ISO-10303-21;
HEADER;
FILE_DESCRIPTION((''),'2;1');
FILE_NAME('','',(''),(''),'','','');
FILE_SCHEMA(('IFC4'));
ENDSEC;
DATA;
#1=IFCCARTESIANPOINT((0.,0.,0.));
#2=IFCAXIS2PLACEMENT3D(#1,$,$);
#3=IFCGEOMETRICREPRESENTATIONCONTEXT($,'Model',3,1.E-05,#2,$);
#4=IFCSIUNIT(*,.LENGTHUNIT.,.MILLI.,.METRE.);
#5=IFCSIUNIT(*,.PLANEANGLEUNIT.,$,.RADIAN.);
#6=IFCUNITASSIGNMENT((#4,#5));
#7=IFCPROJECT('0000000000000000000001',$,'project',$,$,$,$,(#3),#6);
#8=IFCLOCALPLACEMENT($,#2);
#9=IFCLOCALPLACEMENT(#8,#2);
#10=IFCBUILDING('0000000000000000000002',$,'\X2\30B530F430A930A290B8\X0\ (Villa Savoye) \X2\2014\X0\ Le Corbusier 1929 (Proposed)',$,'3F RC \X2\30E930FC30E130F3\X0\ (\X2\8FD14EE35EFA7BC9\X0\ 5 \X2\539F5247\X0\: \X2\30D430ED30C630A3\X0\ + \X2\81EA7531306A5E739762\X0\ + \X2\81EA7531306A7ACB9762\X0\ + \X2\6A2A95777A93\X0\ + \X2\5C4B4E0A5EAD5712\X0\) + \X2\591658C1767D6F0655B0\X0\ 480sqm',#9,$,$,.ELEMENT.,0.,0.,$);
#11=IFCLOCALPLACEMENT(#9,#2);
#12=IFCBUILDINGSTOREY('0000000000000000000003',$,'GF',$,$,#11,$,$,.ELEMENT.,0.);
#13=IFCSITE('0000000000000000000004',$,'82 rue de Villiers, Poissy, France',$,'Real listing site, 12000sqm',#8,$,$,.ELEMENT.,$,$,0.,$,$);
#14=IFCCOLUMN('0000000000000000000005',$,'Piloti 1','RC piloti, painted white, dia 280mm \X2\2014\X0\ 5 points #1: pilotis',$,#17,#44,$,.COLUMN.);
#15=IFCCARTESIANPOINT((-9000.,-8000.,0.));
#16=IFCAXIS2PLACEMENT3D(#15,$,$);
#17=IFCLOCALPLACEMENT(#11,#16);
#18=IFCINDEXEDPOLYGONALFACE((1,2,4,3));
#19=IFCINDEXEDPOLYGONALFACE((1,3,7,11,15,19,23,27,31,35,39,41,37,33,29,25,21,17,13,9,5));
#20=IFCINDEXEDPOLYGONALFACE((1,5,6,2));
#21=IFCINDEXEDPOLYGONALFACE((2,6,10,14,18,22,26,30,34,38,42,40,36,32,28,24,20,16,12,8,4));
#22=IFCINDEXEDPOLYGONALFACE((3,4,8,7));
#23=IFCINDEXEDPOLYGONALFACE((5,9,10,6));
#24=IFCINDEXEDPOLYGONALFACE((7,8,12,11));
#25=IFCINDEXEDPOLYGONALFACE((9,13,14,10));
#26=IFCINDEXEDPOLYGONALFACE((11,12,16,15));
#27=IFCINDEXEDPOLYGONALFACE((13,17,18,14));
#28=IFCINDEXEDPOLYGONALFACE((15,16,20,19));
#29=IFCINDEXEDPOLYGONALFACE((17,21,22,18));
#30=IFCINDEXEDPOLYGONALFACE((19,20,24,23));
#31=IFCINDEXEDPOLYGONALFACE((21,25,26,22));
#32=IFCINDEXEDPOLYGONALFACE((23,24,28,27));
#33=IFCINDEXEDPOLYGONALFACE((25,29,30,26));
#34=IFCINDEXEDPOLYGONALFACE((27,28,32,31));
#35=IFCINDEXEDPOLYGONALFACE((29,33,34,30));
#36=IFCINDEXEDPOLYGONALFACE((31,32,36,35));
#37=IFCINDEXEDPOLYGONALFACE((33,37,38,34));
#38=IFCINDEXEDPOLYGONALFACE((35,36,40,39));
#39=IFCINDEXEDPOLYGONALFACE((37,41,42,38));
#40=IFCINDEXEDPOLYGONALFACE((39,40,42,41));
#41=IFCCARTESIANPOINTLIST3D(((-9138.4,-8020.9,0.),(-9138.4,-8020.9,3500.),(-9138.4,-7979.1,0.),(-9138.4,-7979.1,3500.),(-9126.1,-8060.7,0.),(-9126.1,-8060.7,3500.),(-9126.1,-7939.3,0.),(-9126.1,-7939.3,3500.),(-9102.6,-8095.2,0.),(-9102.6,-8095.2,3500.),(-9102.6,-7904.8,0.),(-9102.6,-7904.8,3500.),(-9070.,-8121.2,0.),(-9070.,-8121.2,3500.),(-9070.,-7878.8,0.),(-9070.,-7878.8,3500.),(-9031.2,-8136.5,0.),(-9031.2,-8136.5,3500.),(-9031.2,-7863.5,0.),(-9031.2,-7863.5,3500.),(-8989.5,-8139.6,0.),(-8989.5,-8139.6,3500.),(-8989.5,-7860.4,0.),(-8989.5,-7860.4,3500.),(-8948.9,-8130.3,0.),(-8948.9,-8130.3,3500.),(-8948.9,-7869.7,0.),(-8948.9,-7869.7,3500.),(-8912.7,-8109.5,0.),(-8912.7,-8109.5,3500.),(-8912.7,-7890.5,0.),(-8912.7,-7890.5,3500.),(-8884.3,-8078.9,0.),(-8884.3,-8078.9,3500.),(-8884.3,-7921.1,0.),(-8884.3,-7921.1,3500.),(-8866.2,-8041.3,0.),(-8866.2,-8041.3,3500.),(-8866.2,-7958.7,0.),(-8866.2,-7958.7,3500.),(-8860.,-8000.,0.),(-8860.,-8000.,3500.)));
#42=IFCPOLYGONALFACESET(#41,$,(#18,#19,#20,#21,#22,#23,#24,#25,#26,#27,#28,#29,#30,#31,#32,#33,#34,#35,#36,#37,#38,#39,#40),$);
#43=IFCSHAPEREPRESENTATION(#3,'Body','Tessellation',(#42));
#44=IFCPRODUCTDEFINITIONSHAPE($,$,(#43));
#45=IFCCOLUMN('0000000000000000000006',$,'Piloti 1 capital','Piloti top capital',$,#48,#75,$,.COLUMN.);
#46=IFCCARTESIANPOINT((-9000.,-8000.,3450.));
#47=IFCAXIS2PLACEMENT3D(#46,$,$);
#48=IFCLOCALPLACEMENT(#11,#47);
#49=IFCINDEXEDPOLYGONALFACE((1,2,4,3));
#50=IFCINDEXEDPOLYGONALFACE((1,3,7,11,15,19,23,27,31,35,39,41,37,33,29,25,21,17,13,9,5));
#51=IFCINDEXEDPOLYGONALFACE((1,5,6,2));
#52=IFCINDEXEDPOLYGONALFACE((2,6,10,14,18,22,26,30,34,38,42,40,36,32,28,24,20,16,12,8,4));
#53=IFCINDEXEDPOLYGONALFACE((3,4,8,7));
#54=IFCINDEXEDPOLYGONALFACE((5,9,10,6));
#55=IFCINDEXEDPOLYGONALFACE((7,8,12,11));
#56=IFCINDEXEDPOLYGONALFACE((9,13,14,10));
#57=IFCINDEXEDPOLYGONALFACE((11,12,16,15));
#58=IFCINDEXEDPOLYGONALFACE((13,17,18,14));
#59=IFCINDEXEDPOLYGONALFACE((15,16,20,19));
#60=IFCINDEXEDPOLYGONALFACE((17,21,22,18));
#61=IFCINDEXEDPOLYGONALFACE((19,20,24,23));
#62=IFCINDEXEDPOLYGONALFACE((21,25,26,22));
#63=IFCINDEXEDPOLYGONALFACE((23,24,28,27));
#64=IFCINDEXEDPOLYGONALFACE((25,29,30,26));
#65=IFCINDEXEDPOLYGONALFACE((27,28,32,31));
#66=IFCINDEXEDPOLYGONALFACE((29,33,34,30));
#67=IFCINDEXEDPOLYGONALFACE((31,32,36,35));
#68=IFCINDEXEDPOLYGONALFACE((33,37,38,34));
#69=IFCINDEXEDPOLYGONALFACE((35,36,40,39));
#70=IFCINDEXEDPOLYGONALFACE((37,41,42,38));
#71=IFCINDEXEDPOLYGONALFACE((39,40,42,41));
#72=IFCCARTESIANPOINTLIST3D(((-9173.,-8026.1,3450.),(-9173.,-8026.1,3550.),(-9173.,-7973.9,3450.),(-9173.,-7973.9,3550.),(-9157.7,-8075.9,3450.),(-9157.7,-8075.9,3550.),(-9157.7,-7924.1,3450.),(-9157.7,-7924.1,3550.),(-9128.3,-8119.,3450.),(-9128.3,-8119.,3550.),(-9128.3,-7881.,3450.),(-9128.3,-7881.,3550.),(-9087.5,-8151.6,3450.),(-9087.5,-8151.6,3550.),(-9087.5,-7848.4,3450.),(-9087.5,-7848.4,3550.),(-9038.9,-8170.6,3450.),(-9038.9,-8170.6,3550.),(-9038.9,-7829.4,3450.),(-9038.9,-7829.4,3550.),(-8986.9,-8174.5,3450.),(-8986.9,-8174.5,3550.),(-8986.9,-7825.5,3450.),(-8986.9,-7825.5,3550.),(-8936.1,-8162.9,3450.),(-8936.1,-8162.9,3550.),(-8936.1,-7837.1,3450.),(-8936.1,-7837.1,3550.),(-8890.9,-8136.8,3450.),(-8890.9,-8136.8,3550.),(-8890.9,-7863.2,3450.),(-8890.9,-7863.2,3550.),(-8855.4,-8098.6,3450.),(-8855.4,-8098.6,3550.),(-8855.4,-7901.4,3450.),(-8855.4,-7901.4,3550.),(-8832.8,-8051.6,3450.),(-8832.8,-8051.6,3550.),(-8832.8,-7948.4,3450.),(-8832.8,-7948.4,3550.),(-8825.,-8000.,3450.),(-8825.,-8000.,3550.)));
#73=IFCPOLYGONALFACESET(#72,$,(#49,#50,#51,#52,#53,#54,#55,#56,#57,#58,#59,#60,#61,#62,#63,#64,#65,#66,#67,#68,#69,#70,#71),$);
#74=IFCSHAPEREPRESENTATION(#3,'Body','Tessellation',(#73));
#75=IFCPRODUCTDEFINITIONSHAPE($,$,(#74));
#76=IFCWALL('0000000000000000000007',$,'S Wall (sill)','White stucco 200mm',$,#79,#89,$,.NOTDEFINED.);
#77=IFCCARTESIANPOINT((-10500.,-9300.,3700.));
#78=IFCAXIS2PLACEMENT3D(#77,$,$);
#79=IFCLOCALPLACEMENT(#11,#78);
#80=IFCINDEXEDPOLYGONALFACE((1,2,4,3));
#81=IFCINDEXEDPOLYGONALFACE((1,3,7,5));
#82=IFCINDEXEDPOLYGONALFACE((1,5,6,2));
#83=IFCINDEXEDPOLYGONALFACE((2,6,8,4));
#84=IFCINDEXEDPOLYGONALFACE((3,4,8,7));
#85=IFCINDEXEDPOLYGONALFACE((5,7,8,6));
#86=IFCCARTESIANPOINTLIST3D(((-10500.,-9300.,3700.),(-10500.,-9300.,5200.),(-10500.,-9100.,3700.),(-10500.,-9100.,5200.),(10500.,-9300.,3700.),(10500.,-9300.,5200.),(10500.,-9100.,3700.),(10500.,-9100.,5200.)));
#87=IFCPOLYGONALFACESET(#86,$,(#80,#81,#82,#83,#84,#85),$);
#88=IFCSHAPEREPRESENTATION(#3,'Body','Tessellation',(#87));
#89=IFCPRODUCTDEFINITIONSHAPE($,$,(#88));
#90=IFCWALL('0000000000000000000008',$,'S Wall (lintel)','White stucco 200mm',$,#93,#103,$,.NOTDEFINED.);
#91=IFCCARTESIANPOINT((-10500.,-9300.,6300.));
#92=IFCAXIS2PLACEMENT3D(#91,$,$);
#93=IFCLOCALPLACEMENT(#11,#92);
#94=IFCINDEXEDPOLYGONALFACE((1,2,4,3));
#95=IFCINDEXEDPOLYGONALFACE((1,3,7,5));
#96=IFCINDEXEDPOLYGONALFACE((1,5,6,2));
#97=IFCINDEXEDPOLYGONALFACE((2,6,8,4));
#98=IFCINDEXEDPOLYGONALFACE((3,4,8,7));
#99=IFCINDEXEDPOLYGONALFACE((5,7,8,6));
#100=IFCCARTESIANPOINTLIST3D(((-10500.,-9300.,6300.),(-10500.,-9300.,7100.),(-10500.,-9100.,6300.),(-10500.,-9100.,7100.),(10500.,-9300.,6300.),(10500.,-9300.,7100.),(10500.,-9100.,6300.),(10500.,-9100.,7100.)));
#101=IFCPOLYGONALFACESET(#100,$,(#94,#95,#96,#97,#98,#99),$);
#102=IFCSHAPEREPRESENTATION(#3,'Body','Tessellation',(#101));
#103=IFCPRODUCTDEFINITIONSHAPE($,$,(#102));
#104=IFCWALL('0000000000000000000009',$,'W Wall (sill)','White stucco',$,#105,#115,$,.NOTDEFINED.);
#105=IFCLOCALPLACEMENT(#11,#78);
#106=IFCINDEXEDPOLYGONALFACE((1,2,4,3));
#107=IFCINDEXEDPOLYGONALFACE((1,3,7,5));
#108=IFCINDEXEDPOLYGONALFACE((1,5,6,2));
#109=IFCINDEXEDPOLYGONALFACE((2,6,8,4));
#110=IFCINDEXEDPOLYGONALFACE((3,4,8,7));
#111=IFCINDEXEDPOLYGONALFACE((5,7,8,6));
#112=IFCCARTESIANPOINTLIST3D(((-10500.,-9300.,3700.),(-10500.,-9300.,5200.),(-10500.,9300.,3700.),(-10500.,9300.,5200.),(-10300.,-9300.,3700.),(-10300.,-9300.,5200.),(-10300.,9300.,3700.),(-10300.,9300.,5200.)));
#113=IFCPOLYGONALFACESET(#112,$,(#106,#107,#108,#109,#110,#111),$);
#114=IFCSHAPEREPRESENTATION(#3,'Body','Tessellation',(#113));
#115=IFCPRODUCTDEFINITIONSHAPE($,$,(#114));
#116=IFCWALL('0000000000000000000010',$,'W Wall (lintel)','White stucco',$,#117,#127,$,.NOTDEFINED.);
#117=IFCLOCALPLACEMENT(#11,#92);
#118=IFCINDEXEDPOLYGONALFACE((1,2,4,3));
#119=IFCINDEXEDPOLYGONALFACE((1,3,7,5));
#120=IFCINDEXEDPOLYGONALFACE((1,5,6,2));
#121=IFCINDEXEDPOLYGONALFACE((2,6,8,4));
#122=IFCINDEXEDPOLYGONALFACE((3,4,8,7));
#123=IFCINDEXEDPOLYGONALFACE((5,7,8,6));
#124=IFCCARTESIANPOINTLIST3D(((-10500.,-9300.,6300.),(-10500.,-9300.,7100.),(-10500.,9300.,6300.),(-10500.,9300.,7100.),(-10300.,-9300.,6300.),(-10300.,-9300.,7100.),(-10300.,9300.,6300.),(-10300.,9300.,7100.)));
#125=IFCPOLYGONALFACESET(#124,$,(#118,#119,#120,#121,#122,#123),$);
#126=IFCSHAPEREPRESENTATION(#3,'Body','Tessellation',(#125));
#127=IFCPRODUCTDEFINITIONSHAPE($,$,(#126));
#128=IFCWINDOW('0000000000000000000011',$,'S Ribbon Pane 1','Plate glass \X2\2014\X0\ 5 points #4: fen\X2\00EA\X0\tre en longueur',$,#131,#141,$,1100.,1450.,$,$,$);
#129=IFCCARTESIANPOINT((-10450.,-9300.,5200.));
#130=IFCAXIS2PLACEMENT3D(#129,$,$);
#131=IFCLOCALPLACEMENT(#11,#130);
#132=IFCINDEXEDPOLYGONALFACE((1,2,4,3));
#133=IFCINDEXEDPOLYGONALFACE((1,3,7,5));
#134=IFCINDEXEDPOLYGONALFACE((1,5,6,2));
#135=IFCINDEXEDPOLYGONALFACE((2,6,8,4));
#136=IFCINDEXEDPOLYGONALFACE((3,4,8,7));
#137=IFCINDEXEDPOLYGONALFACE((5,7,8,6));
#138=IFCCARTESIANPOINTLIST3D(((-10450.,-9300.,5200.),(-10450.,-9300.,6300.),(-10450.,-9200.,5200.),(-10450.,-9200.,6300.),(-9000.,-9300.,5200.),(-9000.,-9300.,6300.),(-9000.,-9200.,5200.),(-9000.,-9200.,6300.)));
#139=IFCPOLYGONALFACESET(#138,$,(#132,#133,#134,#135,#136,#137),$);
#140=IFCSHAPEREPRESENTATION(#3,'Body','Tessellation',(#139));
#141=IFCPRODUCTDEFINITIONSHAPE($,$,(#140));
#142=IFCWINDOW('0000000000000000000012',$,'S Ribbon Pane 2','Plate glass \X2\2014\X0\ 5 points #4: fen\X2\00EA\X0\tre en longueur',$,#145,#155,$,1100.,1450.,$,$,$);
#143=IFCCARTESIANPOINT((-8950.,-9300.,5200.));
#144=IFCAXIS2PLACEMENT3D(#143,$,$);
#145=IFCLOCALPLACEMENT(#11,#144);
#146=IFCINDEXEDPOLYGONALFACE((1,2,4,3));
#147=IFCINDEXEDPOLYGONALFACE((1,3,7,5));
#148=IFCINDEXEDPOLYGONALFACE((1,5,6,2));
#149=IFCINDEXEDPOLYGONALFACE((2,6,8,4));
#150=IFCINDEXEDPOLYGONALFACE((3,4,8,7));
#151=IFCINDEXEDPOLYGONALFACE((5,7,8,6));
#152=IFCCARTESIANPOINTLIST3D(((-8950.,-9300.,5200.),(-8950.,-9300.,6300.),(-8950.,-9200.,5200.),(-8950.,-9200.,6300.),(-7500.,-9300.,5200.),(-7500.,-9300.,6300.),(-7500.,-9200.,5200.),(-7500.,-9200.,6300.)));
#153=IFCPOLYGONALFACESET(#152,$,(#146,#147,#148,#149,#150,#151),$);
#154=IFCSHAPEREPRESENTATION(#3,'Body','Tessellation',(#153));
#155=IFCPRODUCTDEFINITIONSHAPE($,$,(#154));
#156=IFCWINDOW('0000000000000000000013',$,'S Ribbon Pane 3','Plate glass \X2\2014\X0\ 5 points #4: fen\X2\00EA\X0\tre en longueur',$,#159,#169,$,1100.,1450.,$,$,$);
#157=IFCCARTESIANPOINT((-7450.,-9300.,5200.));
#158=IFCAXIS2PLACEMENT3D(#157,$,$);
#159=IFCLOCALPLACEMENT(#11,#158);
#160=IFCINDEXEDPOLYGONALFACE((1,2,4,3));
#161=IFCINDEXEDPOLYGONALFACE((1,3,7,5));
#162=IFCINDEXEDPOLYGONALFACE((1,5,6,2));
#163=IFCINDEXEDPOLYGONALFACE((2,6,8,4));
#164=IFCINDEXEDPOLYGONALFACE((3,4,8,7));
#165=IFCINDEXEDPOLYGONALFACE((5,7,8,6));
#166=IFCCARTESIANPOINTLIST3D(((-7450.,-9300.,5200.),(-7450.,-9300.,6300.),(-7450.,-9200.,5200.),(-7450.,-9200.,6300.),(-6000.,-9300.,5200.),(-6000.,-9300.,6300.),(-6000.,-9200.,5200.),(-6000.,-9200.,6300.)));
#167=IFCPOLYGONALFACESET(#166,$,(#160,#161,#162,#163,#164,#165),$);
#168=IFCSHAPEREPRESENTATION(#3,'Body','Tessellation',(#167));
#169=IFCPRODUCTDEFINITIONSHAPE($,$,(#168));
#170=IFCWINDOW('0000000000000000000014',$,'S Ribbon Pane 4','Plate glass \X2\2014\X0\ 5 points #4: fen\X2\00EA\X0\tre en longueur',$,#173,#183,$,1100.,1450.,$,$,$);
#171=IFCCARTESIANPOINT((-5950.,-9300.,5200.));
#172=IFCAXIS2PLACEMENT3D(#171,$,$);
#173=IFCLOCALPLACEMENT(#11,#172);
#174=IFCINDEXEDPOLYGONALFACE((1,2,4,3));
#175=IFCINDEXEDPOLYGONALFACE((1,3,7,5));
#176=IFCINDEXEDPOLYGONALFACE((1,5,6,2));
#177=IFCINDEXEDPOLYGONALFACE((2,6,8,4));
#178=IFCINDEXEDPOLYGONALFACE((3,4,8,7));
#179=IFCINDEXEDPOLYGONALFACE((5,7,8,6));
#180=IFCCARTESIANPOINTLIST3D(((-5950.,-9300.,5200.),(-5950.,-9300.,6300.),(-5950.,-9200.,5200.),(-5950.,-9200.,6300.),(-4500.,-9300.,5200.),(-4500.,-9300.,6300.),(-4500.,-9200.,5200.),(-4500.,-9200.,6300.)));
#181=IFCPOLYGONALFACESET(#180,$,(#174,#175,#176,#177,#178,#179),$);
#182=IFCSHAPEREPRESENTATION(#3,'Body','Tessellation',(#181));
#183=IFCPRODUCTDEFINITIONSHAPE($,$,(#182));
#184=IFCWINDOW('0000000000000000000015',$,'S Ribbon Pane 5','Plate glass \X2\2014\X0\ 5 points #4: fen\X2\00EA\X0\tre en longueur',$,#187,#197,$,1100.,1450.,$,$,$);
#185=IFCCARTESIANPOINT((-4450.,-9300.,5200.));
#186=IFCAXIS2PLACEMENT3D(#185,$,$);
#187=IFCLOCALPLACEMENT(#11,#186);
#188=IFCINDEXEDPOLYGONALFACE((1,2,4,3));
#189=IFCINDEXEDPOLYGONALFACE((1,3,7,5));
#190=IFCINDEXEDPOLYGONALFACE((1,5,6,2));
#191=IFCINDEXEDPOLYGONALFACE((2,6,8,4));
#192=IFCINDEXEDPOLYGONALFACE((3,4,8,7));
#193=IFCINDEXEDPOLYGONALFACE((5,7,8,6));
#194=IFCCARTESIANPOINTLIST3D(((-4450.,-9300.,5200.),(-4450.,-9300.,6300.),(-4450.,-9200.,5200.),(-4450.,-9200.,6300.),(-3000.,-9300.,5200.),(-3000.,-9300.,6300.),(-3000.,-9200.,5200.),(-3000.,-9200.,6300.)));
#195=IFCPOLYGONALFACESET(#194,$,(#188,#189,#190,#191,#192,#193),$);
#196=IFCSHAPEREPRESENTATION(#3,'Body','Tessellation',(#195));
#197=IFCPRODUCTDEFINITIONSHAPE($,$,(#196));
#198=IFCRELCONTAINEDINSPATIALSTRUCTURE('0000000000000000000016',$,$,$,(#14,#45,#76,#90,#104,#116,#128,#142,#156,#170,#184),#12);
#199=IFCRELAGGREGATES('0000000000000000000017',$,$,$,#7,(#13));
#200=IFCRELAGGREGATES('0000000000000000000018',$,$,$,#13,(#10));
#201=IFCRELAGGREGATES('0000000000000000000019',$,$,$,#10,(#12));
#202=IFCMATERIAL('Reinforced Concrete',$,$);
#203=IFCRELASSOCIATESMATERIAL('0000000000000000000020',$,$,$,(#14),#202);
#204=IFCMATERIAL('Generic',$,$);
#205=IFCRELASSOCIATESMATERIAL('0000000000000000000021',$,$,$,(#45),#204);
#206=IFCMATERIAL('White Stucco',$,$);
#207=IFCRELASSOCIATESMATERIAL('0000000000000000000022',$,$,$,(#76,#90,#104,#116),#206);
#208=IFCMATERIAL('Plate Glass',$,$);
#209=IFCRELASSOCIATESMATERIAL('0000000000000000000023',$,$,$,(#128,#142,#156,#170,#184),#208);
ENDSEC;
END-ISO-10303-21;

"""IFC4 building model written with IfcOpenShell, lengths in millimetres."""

from ifc_helpers import new_model, si_unit, frame, frame_2d, origin, origin_2d, place, context, project, spatial, rectangle, circle, extrude, material, element, save


model = new_model("IFC4")

# Units and contexts
model_context = context("Model", 3, precision=1e-05, world=origin())
ifc_project = project(units=[si_unit("LENGTHUNIT", "METRE", prefix="MILLI"), si_unit("PLANEANGLEUNIT", "RADIAN")], contexts=[model_context])

# Site, building, storey
site_placement = place(None, origin())
site = spatial("IfcSite", under=ifc_project, at=site_placement, Name="82 rue de Villiers, Poissy, France", ObjectType="Real listing site, 12000sqm", CompositionType="ELEMENT", RefElevation=0.0)
building_placement = place(site_placement, origin())
building = spatial("IfcBuilding", under=site, at=building_placement, Name="サヴォア邸 (Villa Savoye) — Le Corbusier 1929 (Proposed)", ObjectType="3F RC ラーメン (近代建築 5 原則: ピロティ + 自由な平面 + 自由な立面 + 横長窓 + 屋上庭園) + 外壁白漆喰 480sqm", CompositionType="ELEMENT", ElevationOfRefHeight=0.0, ElevationOfTerrain=0.0)
storey_placement = place(building_placement, origin())
storey = spatial("IfcBuildingStorey", under=building, at=storey_placement, Name="GF", CompositionType="ELEMENT", Elevation=0.0)

# Columns
ifc_material_1 = material(Name="Reinforced Concrete")
column_1_placement = place(storey_placement, frame((-9000.0, -8000.0, 0.0)))
element("IfcColumn", 1, at=column_1_placement, inside=storey, material=ifc_material_1, Name="Piloti 1", Description="RC piloti, painted white, dia 280mm — 5 points #1: pilotis", PredefinedType="COLUMN", context=model_context, shape_type="SweptSolid", body=[
    extrude(circle(Radius=140.0, at=origin_2d()), frame((-9000.0, -8000.0, 0.0)), (0.0, 0.0, 1.0), 3500.0),
])
ifc_material_2 = material(Name="Generic")
column_2_placement = place(storey_placement, frame((-9000.0, -8000.0, 3450.0)))
element("IfcColumn", 2, at=column_2_placement, inside=storey, material=ifc_material_2, Name="Piloti 1 capital", Description="Piloti top capital", PredefinedType="COLUMN", context=model_context, shape_type="SweptSolid", body=[
    extrude(circle(Radius=175.0, at=origin_2d()), frame((-9000.0, -8000.0, 3450.0)), (0.0, 0.0, 1.0), 100.0),
])

# Walls
ifc_material_3 = material(Name="White Stucco")
wall_1_placement = place(storey_placement, frame((-10500.0, -9300.0, 3700.0)))
element("IfcWall", 3, at=wall_1_placement, inside=storey, material=ifc_material_3, Name="S Wall (sill)", Description="White stucco 200mm", PredefinedType="NOTDEFINED", context=model_context, shape_type="SweptSolid", body=[
    extrude(rectangle(XDim=21000.0, YDim=200.0, at=frame_2d((10500.0, 100.0))), frame((-10500.0, -9300.0, 3700.0)), (0.0, 0.0, 1.0), 1500.0),
])
wall_2_placement = place(storey_placement, frame((-10500.0, -9300.0, 6300.0)))
element("IfcWall", 4, at=wall_2_placement, inside=storey, material=ifc_material_3, Name="S Wall (lintel)", Description="White stucco 200mm", PredefinedType="NOTDEFINED", context=model_context, shape_type="SweptSolid", body=[
    extrude(rectangle(XDim=21000.0, YDim=200.0, at=frame_2d((10500.0, 100.0))), frame((-10500.0, -9300.0, 6300.0)), (0.0, 0.0, 1.0), 800.0),
])
wall_3_placement = place(storey_placement, frame((-10500.0, -9300.0, 3700.0)))
element("IfcWall", 5, at=wall_3_placement, inside=storey, material=ifc_material_3, Name="W Wall (sill)", Description="White stucco", PredefinedType="NOTDEFINED", context=model_context, shape_type="SweptSolid", body=[
    extrude(rectangle(XDim=200.0, YDim=18600.0, at=frame_2d((100.0, 9300.0))), frame((-10500.0, -9300.0, 3700.0)), (0.0, 0.0, 1.0), 1500.0),
])
wall_4_placement = place(storey_placement, frame((-10500.0, -9300.0, 6300.0)))
element("IfcWall", 6, at=wall_4_placement, inside=storey, material=ifc_material_3, Name="W Wall (lintel)", Description="White stucco", PredefinedType="NOTDEFINED", context=model_context, shape_type="SweptSolid", body=[
    extrude(rectangle(XDim=200.0, YDim=18600.0, at=frame_2d((100.0, 9300.0))), frame((-10500.0, -9300.0, 6300.0)), (0.0, 0.0, 1.0), 800.0),
])

# Windows
ifc_material_4 = material(Name="Plate Glass")
window_1_placement = place(storey_placement, frame((-10450.0, -9300.0, 5200.0)))
element("IfcWindow", 7, at=window_1_placement, inside=storey, material=ifc_material_4, Name="S Ribbon Pane 1", Description="Plate glass — 5 points #4: fenêtre en longueur", OverallHeight=1100.0, OverallWidth=1450.0, context=model_context, shape_type="SweptSolid", body=[
    extrude(rectangle(XDim=1450.0, YDim=100.0, at=frame_2d((725.0, 50.0))), frame((-10450.0, -9300.0, 5200.0)), (0.0, 0.0, 1.0), 1100.0),
])
window_2_placement = place(storey_placement, frame((-8950.0, -9300.0, 5200.0)))
element("IfcWindow", 8, at=window_2_placement, inside=storey, material=ifc_material_4, Name="S Ribbon Pane 2", Description="Plate glass — 5 points #4: fenêtre en longueur", OverallHeight=1100.0, OverallWidth=1450.0, context=model_context, shape_type="SweptSolid", body=[
    extrude(rectangle(XDim=1450.0, YDim=100.0, at=frame_2d((725.0, 50.0))), frame((-8950.0, -9300.0, 5200.0)), (0.0, 0.0, 1.0), 1100.0),
])
window_3_placement = place(storey_placement, frame((-7450.0, -9300.0, 5200.0)))
element("IfcWindow", 9, at=window_3_placement, inside=storey, material=ifc_material_4, Name="S Ribbon Pane 3", Description="Plate glass — 5 points #4: fenêtre en longueur", OverallHeight=1100.0, OverallWidth=1450.0, context=model_context, shape_type="SweptSolid", body=[
    extrude(rectangle(XDim=1450.0, YDim=100.0, at=frame_2d((725.0, 50.0))), frame((-7450.0, -9300.0, 5200.0)), (0.0, 0.0, 1.0), 1100.0),
])
window_4_placement = place(storey_placement, frame((-5950.0, -9300.0, 5200.0)))
element("IfcWindow", 10, at=window_4_placement, inside=storey, material=ifc_material_4, Name="S Ribbon Pane 4", Description="Plate glass — 5 points #4: fenêtre en longueur", OverallHeight=1100.0, OverallWidth=1450.0, context=model_context, shape_type="SweptSolid", body=[
    extrude(rectangle(XDim=1450.0, YDim=100.0, at=frame_2d((725.0, 50.0))), frame((-5950.0, -9300.0, 5200.0)), (0.0, 0.0, 1.0), 1100.0),
])
window_5_placement = place(storey_placement, frame((-4450.0, -9300.0, 5200.0)))
element("IfcWindow", 11, at=window_5_placement, inside=storey, material=ifc_material_4, Name="S Ribbon Pane 5", Description="Plate glass — 5 points #4: fenêtre en longueur", OverallHeight=1100.0, OverallWidth=1450.0, context=model_context, shape_type="SweptSolid", body=[
    extrude(rectangle(XDim=1450.0, YDim=100.0, at=frame_2d((725.0, 50.0))), frame((-4450.0, -9300.0, 5200.0)), (0.0, 0.0, 1.0), 1100.0),
])

save(model, "model.ifc")
